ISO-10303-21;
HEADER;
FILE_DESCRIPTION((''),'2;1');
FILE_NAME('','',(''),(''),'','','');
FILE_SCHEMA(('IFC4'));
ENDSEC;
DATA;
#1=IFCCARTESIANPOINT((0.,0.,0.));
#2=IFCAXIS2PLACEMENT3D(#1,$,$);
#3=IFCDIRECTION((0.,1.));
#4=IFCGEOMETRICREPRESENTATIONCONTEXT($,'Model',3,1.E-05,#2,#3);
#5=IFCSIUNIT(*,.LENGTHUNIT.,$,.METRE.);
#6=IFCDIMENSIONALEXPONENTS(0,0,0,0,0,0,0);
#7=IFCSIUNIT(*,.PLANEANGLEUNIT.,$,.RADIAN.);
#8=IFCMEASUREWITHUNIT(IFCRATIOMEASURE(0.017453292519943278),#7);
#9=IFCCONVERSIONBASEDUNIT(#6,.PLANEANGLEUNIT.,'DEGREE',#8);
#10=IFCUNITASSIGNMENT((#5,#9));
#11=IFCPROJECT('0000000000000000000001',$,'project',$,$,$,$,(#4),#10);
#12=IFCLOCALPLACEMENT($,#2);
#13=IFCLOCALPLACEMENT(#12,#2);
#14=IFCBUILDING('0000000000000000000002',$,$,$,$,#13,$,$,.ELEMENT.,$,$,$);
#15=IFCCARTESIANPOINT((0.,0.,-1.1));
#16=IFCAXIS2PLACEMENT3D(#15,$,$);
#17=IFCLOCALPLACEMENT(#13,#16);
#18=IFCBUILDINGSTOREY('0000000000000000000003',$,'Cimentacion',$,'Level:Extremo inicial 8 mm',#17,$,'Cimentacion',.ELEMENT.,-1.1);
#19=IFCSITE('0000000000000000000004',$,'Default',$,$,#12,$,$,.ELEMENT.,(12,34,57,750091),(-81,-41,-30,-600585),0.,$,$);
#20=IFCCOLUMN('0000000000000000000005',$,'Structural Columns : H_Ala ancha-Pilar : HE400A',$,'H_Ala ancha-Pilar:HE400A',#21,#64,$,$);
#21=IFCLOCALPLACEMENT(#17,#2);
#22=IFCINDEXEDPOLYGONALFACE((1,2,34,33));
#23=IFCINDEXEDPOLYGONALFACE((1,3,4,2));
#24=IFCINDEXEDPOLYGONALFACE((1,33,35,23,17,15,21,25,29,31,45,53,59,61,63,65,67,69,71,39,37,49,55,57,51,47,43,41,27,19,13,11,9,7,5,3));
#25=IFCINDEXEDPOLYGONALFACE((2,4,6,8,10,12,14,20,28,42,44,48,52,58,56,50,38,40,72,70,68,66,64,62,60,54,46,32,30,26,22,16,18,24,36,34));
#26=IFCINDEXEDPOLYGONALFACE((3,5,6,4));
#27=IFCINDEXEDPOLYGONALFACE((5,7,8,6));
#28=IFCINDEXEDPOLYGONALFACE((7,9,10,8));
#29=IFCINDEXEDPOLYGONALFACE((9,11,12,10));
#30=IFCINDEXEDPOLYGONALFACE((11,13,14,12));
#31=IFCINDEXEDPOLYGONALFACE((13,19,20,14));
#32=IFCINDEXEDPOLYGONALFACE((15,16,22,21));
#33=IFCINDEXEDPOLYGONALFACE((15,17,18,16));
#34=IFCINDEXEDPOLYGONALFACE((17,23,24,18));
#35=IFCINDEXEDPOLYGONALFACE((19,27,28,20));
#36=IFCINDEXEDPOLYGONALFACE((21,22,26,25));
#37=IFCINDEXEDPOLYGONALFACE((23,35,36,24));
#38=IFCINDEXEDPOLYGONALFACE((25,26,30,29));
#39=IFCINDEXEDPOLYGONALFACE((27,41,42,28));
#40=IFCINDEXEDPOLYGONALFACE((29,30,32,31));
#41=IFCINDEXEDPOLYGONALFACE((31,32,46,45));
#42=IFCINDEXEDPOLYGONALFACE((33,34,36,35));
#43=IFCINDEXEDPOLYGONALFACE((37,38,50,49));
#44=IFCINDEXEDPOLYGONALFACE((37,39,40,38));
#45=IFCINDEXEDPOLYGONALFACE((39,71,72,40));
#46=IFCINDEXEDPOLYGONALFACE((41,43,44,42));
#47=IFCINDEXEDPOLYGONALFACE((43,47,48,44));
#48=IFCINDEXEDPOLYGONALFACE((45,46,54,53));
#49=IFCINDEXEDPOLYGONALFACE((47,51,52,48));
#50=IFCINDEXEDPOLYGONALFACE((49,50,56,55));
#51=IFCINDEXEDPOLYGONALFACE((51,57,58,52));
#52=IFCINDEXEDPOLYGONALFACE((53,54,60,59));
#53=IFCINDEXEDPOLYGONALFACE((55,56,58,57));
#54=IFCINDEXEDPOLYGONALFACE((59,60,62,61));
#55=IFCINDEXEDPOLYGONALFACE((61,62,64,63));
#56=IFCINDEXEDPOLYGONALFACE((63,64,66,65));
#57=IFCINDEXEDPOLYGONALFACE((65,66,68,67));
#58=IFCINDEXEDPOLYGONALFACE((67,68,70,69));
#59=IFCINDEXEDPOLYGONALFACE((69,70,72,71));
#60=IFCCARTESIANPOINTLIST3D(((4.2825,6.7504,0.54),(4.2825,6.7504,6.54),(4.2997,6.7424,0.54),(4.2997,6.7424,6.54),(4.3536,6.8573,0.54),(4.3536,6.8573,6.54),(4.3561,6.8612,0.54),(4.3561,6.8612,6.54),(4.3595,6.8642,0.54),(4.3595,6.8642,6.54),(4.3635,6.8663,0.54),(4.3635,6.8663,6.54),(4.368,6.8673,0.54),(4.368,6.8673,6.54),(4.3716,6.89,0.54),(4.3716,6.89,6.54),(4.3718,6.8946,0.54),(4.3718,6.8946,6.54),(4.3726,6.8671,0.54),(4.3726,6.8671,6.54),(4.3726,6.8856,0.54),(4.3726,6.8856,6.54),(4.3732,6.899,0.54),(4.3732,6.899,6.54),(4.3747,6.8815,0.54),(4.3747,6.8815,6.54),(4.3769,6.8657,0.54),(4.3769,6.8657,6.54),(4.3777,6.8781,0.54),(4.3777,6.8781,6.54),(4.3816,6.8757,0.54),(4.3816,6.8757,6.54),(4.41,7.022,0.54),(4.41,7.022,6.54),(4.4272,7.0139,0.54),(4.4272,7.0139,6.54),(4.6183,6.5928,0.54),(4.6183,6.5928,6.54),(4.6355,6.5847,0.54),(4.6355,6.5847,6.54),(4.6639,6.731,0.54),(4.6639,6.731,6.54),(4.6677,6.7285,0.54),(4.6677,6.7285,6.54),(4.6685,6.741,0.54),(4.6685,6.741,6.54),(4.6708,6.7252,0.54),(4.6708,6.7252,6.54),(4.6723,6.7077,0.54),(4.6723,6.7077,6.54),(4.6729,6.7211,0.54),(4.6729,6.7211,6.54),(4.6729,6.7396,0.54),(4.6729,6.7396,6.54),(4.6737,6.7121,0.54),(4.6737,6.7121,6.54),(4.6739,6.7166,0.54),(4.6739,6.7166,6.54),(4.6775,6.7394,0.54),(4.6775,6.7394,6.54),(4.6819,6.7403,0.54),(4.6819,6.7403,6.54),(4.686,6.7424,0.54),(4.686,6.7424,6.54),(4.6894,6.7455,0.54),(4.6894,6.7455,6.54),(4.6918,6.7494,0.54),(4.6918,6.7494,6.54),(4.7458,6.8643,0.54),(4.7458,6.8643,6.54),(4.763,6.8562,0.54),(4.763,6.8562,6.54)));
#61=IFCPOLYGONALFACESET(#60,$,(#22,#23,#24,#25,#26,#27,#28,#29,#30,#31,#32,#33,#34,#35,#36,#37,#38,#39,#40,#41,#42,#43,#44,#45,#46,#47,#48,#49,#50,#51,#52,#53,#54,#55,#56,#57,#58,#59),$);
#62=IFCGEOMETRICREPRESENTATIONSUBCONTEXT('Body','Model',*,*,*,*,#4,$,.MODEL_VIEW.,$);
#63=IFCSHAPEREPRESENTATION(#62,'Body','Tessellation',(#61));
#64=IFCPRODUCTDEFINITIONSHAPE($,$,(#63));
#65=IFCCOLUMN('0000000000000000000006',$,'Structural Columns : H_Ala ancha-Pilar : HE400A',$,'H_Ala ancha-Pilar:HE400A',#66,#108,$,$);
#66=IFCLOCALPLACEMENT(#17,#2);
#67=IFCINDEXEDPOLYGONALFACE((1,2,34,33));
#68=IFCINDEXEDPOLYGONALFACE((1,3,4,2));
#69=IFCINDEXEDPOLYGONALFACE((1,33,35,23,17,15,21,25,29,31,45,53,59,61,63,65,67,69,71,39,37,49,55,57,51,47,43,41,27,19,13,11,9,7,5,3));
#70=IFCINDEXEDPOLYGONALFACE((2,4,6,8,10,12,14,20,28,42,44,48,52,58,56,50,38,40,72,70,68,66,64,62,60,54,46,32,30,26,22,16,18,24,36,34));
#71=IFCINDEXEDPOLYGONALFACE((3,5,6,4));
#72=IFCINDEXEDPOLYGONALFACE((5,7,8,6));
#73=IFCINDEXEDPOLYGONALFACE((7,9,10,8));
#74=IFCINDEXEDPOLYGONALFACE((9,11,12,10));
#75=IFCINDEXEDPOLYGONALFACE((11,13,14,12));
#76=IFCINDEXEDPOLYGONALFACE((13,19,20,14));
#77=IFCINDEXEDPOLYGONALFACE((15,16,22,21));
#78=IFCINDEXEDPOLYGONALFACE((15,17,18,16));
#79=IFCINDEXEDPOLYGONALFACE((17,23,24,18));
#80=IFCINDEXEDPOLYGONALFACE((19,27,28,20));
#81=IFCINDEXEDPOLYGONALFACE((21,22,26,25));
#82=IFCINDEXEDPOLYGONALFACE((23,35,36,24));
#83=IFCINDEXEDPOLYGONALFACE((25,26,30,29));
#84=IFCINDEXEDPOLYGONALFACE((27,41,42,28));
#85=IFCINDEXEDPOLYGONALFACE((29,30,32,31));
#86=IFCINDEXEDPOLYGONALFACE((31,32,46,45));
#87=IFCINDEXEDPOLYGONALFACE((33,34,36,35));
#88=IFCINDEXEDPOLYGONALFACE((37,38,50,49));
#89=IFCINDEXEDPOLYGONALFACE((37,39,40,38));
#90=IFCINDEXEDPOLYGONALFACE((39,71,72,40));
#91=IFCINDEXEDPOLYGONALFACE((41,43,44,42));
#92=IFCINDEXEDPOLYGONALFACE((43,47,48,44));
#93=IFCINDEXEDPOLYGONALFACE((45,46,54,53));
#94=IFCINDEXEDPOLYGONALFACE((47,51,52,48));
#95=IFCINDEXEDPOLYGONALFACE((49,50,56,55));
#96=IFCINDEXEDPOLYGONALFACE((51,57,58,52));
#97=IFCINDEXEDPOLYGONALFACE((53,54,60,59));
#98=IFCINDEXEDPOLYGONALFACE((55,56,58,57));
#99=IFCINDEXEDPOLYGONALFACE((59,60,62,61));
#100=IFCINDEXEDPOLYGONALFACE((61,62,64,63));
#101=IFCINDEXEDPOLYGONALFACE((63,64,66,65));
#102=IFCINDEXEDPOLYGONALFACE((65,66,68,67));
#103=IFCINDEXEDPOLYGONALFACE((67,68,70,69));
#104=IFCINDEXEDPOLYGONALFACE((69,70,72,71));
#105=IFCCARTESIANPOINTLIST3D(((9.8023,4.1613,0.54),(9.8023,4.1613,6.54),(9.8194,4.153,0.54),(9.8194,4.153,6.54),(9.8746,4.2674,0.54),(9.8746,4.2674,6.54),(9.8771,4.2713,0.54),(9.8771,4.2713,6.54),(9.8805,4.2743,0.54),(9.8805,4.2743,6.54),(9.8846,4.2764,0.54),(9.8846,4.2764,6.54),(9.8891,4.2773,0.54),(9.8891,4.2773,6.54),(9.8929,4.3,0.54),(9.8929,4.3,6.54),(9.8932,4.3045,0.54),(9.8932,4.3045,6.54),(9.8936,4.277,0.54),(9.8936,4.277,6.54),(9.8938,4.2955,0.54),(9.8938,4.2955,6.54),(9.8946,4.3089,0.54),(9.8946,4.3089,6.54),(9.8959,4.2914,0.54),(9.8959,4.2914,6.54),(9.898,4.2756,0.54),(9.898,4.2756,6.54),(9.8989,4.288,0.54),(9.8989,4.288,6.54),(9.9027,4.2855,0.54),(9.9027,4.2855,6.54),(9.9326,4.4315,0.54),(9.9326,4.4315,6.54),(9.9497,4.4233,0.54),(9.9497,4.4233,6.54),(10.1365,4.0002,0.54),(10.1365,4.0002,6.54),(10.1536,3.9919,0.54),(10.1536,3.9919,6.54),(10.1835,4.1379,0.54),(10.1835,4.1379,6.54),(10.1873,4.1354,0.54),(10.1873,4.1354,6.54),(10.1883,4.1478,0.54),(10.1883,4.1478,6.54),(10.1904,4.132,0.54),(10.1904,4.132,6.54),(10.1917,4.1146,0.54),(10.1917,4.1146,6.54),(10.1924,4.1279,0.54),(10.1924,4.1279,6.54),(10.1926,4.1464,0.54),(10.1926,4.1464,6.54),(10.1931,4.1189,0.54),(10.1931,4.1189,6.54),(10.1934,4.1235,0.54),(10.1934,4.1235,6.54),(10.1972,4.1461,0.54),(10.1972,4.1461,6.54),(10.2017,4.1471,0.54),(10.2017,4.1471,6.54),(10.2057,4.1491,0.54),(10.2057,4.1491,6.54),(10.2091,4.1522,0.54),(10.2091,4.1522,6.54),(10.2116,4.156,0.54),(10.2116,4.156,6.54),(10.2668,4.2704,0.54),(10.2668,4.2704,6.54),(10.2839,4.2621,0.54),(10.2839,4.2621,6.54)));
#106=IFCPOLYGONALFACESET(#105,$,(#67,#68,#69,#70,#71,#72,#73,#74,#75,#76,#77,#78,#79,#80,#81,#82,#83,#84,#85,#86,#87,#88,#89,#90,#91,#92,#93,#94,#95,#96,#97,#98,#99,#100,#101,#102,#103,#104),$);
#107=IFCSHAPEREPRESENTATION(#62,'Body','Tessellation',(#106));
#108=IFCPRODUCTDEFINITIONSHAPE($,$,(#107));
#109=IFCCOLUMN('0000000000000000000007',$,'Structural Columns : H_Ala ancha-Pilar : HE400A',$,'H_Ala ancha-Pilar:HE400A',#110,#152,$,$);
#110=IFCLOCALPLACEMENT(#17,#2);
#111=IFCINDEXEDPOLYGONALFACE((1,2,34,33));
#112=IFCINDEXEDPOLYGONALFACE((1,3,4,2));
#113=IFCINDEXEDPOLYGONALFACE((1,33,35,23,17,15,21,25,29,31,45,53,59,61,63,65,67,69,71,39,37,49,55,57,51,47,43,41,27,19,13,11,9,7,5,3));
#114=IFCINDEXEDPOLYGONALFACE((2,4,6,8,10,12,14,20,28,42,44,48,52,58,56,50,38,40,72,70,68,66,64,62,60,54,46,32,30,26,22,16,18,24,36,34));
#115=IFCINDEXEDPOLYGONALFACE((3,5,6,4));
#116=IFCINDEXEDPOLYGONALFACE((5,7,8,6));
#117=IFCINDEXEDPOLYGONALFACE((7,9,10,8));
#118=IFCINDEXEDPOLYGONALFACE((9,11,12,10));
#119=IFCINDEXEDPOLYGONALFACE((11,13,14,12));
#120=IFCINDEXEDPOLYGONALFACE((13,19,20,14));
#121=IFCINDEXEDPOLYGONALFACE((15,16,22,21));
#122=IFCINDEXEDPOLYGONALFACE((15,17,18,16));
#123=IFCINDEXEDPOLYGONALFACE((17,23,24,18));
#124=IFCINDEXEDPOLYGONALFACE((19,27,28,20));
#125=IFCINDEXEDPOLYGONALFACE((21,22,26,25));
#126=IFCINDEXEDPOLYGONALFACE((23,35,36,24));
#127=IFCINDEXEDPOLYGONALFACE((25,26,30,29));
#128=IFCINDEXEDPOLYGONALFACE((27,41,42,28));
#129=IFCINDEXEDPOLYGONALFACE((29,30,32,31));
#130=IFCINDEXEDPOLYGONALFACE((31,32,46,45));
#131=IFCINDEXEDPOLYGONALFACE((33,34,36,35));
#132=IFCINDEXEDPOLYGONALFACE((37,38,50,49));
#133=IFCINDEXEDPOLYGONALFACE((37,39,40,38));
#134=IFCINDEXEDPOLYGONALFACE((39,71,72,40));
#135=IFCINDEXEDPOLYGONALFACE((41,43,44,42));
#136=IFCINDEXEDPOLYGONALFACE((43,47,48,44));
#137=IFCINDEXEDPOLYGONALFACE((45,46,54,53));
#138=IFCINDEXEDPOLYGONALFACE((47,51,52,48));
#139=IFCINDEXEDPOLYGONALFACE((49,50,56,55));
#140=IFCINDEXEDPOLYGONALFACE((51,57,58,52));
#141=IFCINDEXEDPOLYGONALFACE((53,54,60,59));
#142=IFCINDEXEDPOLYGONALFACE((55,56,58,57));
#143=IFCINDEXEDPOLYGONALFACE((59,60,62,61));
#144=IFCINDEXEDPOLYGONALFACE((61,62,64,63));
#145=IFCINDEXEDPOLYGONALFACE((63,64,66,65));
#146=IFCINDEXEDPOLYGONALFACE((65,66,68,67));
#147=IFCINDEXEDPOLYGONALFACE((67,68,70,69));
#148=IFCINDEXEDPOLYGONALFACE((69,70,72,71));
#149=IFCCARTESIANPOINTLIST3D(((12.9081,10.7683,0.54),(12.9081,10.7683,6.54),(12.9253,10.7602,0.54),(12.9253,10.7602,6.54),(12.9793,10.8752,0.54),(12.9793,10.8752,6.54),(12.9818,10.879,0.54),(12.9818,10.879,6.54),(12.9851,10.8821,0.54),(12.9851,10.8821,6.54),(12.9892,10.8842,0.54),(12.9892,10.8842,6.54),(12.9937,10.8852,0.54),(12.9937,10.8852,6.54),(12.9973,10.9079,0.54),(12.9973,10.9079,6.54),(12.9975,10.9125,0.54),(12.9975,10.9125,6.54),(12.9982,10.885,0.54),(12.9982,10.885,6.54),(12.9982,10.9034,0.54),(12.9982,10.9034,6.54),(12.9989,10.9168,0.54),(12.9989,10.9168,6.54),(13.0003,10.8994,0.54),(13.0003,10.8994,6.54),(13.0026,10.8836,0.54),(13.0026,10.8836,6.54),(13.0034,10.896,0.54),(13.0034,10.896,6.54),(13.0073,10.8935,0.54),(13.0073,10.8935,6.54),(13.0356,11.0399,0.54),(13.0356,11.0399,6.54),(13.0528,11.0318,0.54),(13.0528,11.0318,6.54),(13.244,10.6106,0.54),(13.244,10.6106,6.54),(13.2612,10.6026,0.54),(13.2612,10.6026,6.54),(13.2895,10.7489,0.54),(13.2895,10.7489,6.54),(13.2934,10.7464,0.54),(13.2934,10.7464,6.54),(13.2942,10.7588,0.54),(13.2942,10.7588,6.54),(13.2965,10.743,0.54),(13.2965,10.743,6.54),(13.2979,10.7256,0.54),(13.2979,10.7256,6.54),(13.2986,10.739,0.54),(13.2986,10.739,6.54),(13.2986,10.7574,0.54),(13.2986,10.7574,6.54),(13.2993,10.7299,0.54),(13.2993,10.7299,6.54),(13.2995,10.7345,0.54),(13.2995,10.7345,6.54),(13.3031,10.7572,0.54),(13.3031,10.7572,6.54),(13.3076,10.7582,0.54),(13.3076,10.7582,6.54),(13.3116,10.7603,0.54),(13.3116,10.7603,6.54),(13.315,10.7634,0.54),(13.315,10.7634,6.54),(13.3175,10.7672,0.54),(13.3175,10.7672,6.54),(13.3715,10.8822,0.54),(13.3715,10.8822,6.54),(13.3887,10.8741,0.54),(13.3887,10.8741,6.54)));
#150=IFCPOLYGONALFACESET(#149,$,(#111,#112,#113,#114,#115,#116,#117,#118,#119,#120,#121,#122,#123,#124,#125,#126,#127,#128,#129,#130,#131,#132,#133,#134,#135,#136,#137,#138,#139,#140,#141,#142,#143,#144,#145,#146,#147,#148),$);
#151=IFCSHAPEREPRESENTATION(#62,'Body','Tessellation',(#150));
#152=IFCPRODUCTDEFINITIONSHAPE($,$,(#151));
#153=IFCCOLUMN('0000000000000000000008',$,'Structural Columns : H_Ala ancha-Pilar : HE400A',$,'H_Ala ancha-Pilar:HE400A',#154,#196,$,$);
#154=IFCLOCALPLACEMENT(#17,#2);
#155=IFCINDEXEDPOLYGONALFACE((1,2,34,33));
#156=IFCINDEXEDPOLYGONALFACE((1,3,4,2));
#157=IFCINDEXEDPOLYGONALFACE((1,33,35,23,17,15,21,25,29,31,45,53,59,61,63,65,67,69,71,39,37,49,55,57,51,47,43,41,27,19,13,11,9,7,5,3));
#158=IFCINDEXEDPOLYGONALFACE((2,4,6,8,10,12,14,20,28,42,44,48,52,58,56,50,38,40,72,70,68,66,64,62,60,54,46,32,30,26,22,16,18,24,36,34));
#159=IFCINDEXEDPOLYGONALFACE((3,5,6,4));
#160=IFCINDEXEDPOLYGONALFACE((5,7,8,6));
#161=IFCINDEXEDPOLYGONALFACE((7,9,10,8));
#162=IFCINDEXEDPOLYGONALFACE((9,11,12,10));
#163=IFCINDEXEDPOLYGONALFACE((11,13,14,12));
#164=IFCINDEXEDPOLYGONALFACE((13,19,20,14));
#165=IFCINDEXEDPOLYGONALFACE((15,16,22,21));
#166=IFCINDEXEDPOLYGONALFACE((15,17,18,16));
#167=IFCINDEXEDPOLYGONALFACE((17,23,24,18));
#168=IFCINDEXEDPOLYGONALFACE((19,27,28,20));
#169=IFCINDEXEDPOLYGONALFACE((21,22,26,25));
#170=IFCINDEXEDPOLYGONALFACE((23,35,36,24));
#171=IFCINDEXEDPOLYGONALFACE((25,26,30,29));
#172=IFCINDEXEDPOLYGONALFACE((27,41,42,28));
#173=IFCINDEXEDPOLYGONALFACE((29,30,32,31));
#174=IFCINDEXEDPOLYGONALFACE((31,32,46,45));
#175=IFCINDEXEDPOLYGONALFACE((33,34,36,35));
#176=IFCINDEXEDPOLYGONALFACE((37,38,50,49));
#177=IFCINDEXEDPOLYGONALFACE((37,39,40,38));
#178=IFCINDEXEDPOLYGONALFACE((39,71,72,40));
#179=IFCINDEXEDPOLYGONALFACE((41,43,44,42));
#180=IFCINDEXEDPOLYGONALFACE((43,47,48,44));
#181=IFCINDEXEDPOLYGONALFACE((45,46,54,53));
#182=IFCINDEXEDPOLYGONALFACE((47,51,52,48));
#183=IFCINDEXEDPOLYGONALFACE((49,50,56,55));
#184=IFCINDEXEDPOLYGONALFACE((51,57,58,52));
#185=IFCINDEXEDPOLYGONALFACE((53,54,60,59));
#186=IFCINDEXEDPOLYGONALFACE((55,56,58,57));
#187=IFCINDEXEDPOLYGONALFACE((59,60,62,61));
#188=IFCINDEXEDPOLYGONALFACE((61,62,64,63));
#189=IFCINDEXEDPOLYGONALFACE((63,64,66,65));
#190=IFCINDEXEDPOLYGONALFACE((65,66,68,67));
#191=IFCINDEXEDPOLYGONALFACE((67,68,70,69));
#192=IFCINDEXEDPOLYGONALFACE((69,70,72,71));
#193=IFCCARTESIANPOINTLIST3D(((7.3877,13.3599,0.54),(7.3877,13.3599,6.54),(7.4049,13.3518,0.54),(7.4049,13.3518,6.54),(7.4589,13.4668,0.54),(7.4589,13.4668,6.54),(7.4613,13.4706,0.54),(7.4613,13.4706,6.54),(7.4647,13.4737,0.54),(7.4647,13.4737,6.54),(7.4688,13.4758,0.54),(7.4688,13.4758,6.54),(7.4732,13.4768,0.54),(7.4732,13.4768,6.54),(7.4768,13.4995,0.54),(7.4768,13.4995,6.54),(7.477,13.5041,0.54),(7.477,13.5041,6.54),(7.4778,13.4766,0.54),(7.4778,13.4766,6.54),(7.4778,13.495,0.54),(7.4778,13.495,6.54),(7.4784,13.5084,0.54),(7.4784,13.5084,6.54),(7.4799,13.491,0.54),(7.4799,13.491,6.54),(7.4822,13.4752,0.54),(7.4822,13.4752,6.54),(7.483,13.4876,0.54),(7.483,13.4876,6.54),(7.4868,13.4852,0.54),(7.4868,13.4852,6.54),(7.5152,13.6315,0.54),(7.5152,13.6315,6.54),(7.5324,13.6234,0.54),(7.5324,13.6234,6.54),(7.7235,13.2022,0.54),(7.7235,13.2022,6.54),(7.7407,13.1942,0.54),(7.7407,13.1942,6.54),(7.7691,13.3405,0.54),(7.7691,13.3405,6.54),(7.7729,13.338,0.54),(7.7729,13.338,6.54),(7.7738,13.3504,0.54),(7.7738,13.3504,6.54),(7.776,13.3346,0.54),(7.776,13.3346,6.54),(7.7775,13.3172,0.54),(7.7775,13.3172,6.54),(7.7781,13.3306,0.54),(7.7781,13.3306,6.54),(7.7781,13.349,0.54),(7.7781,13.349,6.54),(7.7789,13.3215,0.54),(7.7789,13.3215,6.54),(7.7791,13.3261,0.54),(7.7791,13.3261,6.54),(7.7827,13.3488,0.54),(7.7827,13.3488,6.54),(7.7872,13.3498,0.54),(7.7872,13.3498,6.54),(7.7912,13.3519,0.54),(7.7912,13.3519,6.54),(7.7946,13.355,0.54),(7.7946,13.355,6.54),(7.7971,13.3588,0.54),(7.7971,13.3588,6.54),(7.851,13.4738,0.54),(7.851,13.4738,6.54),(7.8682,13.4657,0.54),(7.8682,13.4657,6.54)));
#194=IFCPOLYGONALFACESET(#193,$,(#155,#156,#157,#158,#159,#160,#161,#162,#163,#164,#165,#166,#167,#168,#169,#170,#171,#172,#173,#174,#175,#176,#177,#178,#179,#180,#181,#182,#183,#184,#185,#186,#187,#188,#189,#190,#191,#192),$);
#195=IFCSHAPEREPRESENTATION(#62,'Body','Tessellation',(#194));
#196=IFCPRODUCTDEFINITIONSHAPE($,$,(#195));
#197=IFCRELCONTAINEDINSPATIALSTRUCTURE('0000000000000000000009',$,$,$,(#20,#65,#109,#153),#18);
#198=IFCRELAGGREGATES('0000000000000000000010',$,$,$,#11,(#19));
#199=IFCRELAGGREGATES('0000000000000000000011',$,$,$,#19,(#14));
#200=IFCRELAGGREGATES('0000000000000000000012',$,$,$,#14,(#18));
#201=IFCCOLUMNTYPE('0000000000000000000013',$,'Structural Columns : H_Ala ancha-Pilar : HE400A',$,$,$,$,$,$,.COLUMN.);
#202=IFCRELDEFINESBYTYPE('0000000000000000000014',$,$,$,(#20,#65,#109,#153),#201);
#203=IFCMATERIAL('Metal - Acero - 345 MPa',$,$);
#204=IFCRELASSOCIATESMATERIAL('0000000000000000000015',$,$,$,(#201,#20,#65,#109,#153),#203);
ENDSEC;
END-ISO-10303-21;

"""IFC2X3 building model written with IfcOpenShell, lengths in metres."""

from ifc_helpers import new_model, entity, si_unit, converted_unit, direction, frame, frame_2d, origin, place, context, subcontext, project, spatial, polyline, circle_curve, parameter, trimmed, segment, composite_curve, outline, extrude, source, transform, mapped, material, type_object, type_shapes, element, save


model = new_model("IFC2X3")

# Units and contexts
model_context = context("Model", 3, precision=1e-05, world=origin(), true_north=direction((0.0, 1.0)))
body_context = subcontext(model_context, "Body", "Model", "MODEL_VIEW")
ifc_project = project(units=[si_unit("LENGTHUNIT", "METRE"), converted_unit("PLANEANGLEUNIT", "DEGREE", entity("IfcRatioMeasure", 0.017453292519943278), si_unit("PLANEANGLEUNIT", "RADIAN"), dimensions=[0, 0, 0, 0, 0, 0, 0])], contexts=[model_context])

# Site, building, storey
site_placement = place(None, origin())
site = spatial("IfcSite", under=ifc_project, at=site_placement, Name="Default", CompositionType="ELEMENT", RefLatitude=(12, 34, 57, 750091), RefLongitude=(-81, -41, -30, -600585), RefElevation=0.0)
building_placement = place(site_placement, origin())
building = spatial("IfcBuilding", under=site, at=building_placement, CompositionType="ELEMENT")
storey_placement = place(building_placement, frame((0.0, 0.0, -1.1)))
storey = spatial("IfcBuildingStorey", under=building, at=storey_placement, Name="Cimentacion", ObjectType="Level:Extremo inicial 8 mm", LongName="Cimentacion", CompositionType="ELEMENT", Elevation=-1.1)

# Columns
ifc_material = material(Name="Metal - Acero - 345 MPa")
column_type_1 = type_object("IfcColumnType", Name="Structural Columns : H_Ala ancha-Pilar : HE400A", PredefinedType="COLUMN", material=ifc_material)
shared_shape_1 = source(origin(), body_context, "Body", "SweptSolid", [
    extrude(outline(composite_curve([segment(polyline([(0.176, -0.15), (0.195, -0.15)]), True, "CONTINUOUS"), segment(polyline([(0.195, -0.15), (0.195, 0.15)]), True, "CONTINUOUS"), segment(polyline([(0.195, 0.15), (0.176, 0.15)]), True, "CONTINUOUS"), segment(polyline([(0.176, 0.15), (0.176, 0.023)]), True, "CONTINUOUS"), segment(trimmed(circle_curve(frame_2d((0.1585, 0.023), x_axis=(1.0, 0.0)), 0.0175), [parameter(270.0)], [parameter(0.0)], True, "PARAMETER"), False, "CONTINUOUS"), segment(polyline([(0.1585, 0.0055), (-0.1585, 0.0055)]), True, "CONTINUOUS"), segment(trimmed(circle_curve(frame_2d((-0.1585, 0.023), x_axis=(0.0, -1.0)), 0.0175), [parameter(270.0)], [parameter(0.0)], True, "PARAMETER"), False, "CONTINUOUS"), segment(polyline([(-0.176, 0.023), (-0.176, 0.15)]), True, "CONTINUOUS"), segment(polyline([(-0.176, 0.15), (-0.195, 0.15)]), True, "CONTINUOUS"), segment(polyline([(-0.195, 0.15), (-0.195, -0.15)]), True, "CONTINUOUS"), segment(polyline([(-0.195, -0.15), (-0.176, -0.15)]), True, "CONTINUOUS"), segment(polyline([(-0.176, -0.15), (-0.176, -0.023)]), True, "CONTINUOUS"), segment(trimmed(circle_curve(frame_2d((-0.1585, -0.023), x_axis=(-1.0, 0.0)), 0.0175), [parameter(270.0)], [parameter(0.0)], True, "PARAMETER"), False, "CONTINUOUS"), segment(polyline([(-0.1585, -0.0055), (0.1585, -0.0055)]), True, "CONTINUOUS"), segment(trimmed(circle_curve(frame_2d((0.1585, -0.023), x_axis=(0.0, 1.0)), 0.0175), [parameter(270.0)], [parameter(0.0)], True, "PARAMETER"), False, "CONTINUOUS"), segment(polyline([(0.176, -0.023), (0.176, -0.15)]), True, "CONTINUOUS")], self_intersect=False)), frame((0.0, 0.0, -0.56), z_axis=(0.0, 0.0, 1.0), x_axis=(0.0, -1.0, 0.0)), (0.0, 0.0, 1.0), 6.0),
])
type_shapes(column_type_1, [shared_shape_1])
for number, where, z_axis, x_axis, name in (
    (1, (4.5227, 6.8033, 1.1), (0.0, 0.0, 1.0), (0.424983, 0.905202, 0.0), "Structural Columns : H_Ala ancha-Pilar : HE400A"),
    (2, (10.0431, 4.2117, 1.1), (0.0, 0.0, 1.0), (0.434341, 0.900749, 0.0), "Structural Columns : H_Ala ancha-Pilar : HE400A"),
    (3, (13.1484, 10.8212, 1.1), (0.0, 0.0, 1.0), (0.42498, 0.905203, 0.0), "Structural Columns : H_Ala ancha-Pilar : HE400A"),
    (4, (7.628, 13.4128, 1.1), (0.0, 0.0, 1.0), (0.424983, 0.905202, 0.0), "Structural Columns : H_Ala ancha-Pilar : HE400A"),
):
    element("IfcColumn", number, at=place(storey_placement, frame(where, z_axis=z_axis, x_axis=x_axis)), inside=storey, type_object=column_type_1, material=ifc_material, Name=name, ObjectType="H_Ala ancha-Pilar:HE400A", context=body_context, shape_type="MappedRepresentation", body=[
        mapped(shared_shape_1, transform((0.0, 0.0, 0.0), scale=1.0)),
    ])

save(model, "model.ifc")
